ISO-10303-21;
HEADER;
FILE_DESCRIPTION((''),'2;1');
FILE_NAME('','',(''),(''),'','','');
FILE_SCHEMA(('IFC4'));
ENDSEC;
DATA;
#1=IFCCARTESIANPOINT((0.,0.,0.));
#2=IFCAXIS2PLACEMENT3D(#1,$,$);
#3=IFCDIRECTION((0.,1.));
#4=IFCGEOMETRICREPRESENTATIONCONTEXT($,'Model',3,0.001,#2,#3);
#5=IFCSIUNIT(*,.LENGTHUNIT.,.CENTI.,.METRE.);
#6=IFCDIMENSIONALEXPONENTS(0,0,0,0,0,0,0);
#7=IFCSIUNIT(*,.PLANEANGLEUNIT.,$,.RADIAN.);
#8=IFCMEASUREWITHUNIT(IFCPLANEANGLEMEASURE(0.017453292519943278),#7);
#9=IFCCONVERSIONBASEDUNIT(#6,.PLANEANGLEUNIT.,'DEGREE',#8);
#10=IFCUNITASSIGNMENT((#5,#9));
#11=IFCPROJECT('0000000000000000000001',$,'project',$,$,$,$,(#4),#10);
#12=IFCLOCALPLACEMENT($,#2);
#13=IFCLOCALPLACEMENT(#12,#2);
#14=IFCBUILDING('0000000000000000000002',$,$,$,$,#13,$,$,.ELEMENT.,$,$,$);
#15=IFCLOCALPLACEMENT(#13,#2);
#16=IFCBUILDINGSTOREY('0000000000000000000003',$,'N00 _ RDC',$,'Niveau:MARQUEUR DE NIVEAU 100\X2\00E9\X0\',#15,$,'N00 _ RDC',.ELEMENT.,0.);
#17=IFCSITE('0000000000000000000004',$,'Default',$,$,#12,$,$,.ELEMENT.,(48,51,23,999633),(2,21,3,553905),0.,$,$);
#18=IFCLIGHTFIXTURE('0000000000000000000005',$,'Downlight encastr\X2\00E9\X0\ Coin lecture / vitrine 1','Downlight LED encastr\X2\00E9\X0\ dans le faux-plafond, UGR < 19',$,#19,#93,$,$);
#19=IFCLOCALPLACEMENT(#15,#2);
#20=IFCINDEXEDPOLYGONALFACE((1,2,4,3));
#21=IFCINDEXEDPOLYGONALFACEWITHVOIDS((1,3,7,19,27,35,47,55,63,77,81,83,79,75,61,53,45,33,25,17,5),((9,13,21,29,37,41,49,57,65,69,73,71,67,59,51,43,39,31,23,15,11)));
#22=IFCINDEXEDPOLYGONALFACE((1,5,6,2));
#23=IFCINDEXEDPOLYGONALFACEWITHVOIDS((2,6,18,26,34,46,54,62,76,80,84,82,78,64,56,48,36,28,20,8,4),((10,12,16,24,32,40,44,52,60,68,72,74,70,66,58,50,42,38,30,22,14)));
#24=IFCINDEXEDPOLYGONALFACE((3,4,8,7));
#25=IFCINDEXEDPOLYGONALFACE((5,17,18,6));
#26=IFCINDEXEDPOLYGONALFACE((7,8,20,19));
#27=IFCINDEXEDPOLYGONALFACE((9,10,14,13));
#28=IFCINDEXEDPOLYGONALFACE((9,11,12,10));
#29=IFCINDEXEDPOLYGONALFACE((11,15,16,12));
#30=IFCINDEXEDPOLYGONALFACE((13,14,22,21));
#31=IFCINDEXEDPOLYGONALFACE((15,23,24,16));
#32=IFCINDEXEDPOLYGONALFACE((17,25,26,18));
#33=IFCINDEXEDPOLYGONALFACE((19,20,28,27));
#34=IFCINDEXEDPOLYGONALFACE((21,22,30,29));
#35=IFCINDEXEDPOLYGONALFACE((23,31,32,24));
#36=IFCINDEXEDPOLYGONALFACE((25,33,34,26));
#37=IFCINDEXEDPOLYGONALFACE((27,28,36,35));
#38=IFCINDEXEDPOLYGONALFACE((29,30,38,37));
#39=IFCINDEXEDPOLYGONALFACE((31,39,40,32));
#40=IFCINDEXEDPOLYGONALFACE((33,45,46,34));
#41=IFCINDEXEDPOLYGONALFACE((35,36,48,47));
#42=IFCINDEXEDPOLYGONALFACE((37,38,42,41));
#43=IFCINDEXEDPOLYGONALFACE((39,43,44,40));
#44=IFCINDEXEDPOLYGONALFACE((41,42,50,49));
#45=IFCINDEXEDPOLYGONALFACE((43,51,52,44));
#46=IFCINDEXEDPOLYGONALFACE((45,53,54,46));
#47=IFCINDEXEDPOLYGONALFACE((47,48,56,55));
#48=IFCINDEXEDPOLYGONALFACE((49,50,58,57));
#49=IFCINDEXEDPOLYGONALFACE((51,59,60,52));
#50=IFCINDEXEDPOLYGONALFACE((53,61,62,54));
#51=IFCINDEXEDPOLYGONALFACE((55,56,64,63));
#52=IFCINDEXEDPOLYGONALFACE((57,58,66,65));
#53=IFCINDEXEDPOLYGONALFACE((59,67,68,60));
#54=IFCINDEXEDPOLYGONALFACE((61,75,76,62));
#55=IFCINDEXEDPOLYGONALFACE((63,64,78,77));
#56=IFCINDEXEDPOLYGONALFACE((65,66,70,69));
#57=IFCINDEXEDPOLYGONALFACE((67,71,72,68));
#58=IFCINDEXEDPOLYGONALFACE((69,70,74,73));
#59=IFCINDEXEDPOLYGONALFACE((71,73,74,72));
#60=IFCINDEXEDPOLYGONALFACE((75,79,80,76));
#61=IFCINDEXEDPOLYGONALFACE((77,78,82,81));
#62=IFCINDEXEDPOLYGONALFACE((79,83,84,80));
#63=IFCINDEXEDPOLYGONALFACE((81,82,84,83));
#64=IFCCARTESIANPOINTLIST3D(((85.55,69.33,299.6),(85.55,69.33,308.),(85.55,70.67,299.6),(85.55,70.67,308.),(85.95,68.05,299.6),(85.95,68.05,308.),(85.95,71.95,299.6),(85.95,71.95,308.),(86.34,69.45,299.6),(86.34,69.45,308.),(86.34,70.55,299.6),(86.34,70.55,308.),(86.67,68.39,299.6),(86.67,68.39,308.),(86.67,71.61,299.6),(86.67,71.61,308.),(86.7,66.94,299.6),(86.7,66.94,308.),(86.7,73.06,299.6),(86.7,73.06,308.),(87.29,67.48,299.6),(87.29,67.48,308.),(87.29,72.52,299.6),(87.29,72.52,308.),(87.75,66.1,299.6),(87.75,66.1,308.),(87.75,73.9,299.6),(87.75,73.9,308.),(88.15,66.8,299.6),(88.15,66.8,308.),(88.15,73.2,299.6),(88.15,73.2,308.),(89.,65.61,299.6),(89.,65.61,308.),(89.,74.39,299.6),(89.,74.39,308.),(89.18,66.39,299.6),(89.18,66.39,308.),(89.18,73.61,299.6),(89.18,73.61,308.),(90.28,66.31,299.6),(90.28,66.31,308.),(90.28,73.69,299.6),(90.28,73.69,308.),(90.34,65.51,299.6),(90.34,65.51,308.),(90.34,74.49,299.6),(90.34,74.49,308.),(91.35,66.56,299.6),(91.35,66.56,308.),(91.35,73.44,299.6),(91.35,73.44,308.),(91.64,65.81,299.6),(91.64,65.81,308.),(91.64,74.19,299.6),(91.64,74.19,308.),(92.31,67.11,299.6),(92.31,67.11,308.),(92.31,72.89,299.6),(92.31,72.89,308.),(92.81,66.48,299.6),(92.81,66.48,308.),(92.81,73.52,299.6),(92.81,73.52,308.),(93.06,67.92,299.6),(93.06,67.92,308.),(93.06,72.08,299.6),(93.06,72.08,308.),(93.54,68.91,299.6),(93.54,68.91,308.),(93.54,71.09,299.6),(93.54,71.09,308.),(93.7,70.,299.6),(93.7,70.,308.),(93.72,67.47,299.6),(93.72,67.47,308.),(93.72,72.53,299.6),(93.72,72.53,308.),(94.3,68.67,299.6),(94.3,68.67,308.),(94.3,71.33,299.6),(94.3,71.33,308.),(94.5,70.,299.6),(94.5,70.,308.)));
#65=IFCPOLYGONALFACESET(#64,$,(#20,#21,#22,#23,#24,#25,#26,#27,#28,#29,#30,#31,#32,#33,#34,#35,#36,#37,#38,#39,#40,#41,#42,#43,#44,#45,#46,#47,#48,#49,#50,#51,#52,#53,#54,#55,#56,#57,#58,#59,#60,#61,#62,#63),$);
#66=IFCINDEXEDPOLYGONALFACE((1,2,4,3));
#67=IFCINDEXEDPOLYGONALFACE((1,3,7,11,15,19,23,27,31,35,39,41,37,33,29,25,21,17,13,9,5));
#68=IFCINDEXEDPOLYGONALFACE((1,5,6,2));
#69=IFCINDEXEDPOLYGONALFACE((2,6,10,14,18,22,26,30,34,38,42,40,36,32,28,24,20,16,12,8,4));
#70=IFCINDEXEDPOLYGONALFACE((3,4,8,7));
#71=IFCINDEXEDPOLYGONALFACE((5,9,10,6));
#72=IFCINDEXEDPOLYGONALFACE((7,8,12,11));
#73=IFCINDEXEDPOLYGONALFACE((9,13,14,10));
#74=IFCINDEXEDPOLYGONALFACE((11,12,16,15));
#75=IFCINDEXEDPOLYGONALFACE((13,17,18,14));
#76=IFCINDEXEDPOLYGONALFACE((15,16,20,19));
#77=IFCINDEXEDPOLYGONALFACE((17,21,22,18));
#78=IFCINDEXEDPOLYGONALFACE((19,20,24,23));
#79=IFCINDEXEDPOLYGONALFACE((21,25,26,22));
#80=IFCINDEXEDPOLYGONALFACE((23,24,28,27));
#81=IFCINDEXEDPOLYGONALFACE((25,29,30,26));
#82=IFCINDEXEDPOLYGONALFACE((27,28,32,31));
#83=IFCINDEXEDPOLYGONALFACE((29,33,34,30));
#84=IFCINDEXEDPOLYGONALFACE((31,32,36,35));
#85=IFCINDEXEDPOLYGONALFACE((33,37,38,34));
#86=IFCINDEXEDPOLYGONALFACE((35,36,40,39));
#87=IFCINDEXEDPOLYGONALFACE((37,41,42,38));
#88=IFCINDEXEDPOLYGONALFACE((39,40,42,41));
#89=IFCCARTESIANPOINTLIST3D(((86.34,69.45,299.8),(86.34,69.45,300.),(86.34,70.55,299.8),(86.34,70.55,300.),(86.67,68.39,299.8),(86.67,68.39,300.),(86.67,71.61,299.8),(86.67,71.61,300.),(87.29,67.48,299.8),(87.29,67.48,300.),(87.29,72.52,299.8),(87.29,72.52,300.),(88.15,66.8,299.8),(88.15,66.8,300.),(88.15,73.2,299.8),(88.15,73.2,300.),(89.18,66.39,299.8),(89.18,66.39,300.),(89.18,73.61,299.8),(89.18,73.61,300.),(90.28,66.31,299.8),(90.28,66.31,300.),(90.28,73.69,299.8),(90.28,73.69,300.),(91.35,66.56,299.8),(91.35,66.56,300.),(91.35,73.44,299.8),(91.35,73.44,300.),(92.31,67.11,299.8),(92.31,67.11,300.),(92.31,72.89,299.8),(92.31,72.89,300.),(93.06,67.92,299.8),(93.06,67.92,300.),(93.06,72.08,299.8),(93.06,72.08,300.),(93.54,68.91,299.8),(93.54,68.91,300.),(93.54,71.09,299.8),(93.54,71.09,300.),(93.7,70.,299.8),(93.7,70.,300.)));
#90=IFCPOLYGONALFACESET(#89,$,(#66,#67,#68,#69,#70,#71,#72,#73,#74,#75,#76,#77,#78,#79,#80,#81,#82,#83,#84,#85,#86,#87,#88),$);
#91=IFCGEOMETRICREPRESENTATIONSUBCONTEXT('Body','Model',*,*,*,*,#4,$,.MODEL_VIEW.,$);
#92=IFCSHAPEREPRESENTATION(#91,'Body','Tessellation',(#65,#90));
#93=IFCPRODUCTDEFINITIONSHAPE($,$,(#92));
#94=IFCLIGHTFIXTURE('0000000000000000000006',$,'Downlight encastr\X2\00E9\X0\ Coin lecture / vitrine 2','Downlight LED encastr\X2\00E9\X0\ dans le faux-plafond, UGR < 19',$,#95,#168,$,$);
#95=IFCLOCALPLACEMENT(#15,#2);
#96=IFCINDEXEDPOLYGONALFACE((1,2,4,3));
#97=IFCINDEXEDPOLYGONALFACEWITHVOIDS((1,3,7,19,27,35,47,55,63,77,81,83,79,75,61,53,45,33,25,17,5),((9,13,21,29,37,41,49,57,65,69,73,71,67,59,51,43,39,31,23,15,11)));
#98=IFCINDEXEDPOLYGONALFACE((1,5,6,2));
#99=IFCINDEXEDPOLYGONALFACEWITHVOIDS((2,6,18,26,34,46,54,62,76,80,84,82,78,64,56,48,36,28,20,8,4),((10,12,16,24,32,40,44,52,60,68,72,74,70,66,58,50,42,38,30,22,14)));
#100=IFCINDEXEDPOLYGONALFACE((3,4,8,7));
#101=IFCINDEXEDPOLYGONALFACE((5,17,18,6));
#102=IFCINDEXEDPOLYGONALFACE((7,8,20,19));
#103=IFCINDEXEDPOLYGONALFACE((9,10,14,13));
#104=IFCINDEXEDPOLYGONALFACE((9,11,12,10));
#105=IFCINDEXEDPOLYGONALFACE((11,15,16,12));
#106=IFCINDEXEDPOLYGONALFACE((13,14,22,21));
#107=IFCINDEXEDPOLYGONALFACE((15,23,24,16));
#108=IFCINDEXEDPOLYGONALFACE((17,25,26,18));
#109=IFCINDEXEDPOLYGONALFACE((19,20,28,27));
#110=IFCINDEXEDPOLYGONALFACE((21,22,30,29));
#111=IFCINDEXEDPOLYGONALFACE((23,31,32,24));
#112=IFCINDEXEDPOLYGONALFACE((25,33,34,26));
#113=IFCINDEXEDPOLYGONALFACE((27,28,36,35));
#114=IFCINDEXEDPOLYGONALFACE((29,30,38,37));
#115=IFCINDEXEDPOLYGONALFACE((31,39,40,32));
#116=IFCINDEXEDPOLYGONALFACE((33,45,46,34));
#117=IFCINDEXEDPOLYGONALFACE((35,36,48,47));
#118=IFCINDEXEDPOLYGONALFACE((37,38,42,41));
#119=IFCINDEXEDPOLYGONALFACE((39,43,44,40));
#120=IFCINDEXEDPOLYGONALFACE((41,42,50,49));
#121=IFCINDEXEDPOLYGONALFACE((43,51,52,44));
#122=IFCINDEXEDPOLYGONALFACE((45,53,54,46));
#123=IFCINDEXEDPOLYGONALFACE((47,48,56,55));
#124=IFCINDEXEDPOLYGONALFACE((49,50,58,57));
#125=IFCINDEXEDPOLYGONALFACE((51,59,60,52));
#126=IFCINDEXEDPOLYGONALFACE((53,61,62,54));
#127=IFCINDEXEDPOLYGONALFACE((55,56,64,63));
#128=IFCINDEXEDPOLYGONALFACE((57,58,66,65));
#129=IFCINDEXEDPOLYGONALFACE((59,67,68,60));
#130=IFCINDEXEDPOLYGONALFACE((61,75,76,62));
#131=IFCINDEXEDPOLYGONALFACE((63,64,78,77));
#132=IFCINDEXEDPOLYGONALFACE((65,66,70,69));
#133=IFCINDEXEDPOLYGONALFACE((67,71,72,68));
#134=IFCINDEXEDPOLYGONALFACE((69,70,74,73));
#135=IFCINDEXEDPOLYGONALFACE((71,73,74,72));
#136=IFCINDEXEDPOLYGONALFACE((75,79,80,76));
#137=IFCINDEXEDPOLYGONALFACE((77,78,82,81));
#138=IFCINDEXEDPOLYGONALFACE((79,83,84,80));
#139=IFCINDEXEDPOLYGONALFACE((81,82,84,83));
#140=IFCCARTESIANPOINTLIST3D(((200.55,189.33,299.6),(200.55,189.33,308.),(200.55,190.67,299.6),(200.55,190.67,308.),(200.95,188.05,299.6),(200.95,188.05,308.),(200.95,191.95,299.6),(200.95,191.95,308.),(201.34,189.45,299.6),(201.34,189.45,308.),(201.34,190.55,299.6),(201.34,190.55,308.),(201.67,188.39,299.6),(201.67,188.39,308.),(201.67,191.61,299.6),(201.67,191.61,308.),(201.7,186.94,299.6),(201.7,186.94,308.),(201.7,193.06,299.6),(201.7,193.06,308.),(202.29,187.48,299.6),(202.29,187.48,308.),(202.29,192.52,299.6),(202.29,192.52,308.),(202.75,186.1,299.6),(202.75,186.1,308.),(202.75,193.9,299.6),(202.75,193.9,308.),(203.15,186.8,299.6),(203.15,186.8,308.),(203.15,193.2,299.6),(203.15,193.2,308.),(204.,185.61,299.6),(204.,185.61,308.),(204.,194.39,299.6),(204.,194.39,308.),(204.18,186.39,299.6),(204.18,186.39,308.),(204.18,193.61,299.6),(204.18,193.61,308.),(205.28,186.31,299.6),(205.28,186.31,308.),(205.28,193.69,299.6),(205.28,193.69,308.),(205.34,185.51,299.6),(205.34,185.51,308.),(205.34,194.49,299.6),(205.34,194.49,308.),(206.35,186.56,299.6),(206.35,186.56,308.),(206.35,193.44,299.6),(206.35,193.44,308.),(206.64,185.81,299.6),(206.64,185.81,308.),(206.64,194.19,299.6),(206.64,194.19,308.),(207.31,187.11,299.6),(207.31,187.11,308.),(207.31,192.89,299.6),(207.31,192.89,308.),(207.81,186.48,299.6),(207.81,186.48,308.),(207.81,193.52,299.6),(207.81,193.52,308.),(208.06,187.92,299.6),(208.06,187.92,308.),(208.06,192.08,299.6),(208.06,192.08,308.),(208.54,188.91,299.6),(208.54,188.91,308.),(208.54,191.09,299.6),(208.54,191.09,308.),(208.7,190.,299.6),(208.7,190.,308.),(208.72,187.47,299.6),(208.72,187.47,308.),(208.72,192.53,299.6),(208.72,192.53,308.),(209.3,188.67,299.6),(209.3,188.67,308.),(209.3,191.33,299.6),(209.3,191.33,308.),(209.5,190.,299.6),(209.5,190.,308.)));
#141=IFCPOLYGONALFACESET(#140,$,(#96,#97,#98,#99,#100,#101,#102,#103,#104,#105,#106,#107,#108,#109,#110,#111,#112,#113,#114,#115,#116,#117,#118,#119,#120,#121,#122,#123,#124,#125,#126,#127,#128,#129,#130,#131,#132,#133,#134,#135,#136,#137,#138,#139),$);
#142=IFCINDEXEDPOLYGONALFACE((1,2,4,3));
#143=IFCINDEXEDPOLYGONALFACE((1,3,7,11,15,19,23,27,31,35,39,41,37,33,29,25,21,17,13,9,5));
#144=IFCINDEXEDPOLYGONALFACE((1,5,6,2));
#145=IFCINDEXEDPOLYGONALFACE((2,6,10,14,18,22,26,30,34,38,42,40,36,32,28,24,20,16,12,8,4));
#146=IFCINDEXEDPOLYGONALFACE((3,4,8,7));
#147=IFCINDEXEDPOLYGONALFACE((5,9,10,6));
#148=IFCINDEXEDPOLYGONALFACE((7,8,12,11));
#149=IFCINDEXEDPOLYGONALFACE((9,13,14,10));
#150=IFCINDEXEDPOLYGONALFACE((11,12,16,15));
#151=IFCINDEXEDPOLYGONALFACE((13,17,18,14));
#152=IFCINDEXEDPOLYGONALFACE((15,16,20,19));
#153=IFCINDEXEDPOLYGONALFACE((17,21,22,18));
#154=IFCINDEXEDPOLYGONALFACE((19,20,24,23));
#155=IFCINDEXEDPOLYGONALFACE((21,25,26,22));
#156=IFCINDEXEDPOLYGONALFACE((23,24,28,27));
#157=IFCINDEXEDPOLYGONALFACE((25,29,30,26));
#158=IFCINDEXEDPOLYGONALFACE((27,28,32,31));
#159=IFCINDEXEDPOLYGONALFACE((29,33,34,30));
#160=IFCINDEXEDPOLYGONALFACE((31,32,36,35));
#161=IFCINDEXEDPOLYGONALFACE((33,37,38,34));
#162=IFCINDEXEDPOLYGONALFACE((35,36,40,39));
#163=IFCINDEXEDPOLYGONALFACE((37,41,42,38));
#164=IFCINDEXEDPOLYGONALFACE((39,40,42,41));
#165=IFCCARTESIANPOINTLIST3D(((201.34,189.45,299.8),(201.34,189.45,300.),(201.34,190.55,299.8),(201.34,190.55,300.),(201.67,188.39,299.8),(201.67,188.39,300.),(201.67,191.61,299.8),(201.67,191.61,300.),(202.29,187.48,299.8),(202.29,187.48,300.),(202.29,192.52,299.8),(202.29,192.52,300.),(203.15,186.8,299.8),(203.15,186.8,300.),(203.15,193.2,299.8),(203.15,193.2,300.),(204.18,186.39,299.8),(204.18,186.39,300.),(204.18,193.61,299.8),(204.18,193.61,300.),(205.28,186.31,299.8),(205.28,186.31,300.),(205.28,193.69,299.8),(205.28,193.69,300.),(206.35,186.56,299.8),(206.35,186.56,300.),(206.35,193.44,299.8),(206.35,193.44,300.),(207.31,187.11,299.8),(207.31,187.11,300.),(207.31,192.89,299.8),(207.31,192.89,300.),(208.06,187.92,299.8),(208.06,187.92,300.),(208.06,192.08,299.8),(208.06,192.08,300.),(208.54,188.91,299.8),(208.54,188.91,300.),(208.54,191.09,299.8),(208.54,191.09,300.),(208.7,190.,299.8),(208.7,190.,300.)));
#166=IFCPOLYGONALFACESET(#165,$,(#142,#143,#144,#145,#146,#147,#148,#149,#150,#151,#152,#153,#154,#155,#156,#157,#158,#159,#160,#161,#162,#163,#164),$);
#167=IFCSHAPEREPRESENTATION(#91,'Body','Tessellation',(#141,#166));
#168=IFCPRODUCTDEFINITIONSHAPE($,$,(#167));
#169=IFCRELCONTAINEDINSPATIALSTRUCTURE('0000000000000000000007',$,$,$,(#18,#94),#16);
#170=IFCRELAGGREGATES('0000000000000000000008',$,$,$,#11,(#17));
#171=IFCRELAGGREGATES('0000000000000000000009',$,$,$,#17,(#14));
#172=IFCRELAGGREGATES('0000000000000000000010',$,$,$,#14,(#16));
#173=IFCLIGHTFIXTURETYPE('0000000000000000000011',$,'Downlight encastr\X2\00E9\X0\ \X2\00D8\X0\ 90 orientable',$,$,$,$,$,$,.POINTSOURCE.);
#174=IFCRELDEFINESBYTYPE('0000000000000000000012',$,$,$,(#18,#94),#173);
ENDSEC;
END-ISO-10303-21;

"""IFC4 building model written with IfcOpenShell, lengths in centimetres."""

from ifc_helpers import new_model, entity, si_unit, converted_unit, direction, frame, frame_2d, origin, origin_with_axes, place, context, subcontext, project, spatial, circle, hollow_circle, extrude, type_object, element, save


model = new_model("IFC4")

# Units and contexts
model_context = context("Model", 3, precision=0.001, world=origin(), true_north=direction((0.0, 1.0)))
body_context = subcontext(model_context, "Body", "Model", "MODEL_VIEW")
ifc_project = project(units=[si_unit("LENGTHUNIT", "METRE", prefix="CENTI"), converted_unit("PLANEANGLEUNIT", "DEGREE", entity("IfcPlaneAngleMeasure", 0.017453292519943278), si_unit("PLANEANGLEUNIT", "RADIAN"), dimensions=[0, 0, 0, 0, 0, 0, 0])], contexts=[model_context])

# Site, building, storey
site_placement = place(None, origin())
site = spatial("IfcSite", under=ifc_project, at=site_placement, Name="Default", CompositionType="ELEMENT", RefLatitude=(48, 51, 23, 999633), RefLongitude=(2, 21, 3, 553905), RefElevation=0.0)
building_placement = place(site_placement, origin())
building = spatial("IfcBuilding", under=site, at=building_placement, CompositionType="ELEMENT")
storey_placement = place(building_placement, origin())
storey = spatial("IfcBuildingStorey", under=building, at=storey_placement, Name="N00 _ RDC", ObjectType="Niveau:MARQUEUR DE NIVEAU 100é", LongName="N00 _ RDC", CompositionType="ELEMENT", Elevation=0.0)

# Light fixtures
light_fixture_type_1 = type_object("IfcLightFixtureType", Name="Downlight encastré Ø 90 orientable", PredefinedType="POINTSOURCE")
light_fixture_1_placement = place(storey_placement, origin_with_axes())
element("IfcLightFixture", 1, at=light_fixture_1_placement, inside=storey, type_object=light_fixture_type_1, Name="Downlight encastré Coin lecture / vitrine 1", Description="Downlight LED encastré dans le faux-plafond, UGR < 19", context=body_context, shape_type="SweptSolid", body=[
    extrude(hollow_circle(Radius=4.5, WallThickness=0.8, at=frame_2d((90.0, 70.0))), frame((0.0, 0.0, 299.6)), (0.0, 0.0, 1.0), 8.4),
    extrude(circle(Radius=3.7, at=frame_2d((90.0, 70.0))), frame((0.0, 0.0, 299.8)), (0.0, 0.0, 1.0), 0.2),
])
light_fixture_2_placement = place(storey_placement, origin_with_axes())
element("IfcLightFixture", 2, at=light_fixture_2_placement, inside=storey, type_object=light_fixture_type_1, Name="Downlight encastré Coin lecture / vitrine 2", Description="Downlight LED encastré dans le faux-plafond, UGR < 19", context=body_context, shape_type="SweptSolid", body=[
    extrude(hollow_circle(Radius=4.5, WallThickness=0.8, at=frame_2d((205.0, 190.0))), frame((0.0, 0.0, 299.6)), (0.0, 0.0, 1.0), 8.4),
    extrude(circle(Radius=3.7, at=frame_2d((205.0, 190.0))), frame((0.0, 0.0, 299.8)), (0.0, 0.0, 1.0), 0.2),
])

save(model, "model.ifc")
